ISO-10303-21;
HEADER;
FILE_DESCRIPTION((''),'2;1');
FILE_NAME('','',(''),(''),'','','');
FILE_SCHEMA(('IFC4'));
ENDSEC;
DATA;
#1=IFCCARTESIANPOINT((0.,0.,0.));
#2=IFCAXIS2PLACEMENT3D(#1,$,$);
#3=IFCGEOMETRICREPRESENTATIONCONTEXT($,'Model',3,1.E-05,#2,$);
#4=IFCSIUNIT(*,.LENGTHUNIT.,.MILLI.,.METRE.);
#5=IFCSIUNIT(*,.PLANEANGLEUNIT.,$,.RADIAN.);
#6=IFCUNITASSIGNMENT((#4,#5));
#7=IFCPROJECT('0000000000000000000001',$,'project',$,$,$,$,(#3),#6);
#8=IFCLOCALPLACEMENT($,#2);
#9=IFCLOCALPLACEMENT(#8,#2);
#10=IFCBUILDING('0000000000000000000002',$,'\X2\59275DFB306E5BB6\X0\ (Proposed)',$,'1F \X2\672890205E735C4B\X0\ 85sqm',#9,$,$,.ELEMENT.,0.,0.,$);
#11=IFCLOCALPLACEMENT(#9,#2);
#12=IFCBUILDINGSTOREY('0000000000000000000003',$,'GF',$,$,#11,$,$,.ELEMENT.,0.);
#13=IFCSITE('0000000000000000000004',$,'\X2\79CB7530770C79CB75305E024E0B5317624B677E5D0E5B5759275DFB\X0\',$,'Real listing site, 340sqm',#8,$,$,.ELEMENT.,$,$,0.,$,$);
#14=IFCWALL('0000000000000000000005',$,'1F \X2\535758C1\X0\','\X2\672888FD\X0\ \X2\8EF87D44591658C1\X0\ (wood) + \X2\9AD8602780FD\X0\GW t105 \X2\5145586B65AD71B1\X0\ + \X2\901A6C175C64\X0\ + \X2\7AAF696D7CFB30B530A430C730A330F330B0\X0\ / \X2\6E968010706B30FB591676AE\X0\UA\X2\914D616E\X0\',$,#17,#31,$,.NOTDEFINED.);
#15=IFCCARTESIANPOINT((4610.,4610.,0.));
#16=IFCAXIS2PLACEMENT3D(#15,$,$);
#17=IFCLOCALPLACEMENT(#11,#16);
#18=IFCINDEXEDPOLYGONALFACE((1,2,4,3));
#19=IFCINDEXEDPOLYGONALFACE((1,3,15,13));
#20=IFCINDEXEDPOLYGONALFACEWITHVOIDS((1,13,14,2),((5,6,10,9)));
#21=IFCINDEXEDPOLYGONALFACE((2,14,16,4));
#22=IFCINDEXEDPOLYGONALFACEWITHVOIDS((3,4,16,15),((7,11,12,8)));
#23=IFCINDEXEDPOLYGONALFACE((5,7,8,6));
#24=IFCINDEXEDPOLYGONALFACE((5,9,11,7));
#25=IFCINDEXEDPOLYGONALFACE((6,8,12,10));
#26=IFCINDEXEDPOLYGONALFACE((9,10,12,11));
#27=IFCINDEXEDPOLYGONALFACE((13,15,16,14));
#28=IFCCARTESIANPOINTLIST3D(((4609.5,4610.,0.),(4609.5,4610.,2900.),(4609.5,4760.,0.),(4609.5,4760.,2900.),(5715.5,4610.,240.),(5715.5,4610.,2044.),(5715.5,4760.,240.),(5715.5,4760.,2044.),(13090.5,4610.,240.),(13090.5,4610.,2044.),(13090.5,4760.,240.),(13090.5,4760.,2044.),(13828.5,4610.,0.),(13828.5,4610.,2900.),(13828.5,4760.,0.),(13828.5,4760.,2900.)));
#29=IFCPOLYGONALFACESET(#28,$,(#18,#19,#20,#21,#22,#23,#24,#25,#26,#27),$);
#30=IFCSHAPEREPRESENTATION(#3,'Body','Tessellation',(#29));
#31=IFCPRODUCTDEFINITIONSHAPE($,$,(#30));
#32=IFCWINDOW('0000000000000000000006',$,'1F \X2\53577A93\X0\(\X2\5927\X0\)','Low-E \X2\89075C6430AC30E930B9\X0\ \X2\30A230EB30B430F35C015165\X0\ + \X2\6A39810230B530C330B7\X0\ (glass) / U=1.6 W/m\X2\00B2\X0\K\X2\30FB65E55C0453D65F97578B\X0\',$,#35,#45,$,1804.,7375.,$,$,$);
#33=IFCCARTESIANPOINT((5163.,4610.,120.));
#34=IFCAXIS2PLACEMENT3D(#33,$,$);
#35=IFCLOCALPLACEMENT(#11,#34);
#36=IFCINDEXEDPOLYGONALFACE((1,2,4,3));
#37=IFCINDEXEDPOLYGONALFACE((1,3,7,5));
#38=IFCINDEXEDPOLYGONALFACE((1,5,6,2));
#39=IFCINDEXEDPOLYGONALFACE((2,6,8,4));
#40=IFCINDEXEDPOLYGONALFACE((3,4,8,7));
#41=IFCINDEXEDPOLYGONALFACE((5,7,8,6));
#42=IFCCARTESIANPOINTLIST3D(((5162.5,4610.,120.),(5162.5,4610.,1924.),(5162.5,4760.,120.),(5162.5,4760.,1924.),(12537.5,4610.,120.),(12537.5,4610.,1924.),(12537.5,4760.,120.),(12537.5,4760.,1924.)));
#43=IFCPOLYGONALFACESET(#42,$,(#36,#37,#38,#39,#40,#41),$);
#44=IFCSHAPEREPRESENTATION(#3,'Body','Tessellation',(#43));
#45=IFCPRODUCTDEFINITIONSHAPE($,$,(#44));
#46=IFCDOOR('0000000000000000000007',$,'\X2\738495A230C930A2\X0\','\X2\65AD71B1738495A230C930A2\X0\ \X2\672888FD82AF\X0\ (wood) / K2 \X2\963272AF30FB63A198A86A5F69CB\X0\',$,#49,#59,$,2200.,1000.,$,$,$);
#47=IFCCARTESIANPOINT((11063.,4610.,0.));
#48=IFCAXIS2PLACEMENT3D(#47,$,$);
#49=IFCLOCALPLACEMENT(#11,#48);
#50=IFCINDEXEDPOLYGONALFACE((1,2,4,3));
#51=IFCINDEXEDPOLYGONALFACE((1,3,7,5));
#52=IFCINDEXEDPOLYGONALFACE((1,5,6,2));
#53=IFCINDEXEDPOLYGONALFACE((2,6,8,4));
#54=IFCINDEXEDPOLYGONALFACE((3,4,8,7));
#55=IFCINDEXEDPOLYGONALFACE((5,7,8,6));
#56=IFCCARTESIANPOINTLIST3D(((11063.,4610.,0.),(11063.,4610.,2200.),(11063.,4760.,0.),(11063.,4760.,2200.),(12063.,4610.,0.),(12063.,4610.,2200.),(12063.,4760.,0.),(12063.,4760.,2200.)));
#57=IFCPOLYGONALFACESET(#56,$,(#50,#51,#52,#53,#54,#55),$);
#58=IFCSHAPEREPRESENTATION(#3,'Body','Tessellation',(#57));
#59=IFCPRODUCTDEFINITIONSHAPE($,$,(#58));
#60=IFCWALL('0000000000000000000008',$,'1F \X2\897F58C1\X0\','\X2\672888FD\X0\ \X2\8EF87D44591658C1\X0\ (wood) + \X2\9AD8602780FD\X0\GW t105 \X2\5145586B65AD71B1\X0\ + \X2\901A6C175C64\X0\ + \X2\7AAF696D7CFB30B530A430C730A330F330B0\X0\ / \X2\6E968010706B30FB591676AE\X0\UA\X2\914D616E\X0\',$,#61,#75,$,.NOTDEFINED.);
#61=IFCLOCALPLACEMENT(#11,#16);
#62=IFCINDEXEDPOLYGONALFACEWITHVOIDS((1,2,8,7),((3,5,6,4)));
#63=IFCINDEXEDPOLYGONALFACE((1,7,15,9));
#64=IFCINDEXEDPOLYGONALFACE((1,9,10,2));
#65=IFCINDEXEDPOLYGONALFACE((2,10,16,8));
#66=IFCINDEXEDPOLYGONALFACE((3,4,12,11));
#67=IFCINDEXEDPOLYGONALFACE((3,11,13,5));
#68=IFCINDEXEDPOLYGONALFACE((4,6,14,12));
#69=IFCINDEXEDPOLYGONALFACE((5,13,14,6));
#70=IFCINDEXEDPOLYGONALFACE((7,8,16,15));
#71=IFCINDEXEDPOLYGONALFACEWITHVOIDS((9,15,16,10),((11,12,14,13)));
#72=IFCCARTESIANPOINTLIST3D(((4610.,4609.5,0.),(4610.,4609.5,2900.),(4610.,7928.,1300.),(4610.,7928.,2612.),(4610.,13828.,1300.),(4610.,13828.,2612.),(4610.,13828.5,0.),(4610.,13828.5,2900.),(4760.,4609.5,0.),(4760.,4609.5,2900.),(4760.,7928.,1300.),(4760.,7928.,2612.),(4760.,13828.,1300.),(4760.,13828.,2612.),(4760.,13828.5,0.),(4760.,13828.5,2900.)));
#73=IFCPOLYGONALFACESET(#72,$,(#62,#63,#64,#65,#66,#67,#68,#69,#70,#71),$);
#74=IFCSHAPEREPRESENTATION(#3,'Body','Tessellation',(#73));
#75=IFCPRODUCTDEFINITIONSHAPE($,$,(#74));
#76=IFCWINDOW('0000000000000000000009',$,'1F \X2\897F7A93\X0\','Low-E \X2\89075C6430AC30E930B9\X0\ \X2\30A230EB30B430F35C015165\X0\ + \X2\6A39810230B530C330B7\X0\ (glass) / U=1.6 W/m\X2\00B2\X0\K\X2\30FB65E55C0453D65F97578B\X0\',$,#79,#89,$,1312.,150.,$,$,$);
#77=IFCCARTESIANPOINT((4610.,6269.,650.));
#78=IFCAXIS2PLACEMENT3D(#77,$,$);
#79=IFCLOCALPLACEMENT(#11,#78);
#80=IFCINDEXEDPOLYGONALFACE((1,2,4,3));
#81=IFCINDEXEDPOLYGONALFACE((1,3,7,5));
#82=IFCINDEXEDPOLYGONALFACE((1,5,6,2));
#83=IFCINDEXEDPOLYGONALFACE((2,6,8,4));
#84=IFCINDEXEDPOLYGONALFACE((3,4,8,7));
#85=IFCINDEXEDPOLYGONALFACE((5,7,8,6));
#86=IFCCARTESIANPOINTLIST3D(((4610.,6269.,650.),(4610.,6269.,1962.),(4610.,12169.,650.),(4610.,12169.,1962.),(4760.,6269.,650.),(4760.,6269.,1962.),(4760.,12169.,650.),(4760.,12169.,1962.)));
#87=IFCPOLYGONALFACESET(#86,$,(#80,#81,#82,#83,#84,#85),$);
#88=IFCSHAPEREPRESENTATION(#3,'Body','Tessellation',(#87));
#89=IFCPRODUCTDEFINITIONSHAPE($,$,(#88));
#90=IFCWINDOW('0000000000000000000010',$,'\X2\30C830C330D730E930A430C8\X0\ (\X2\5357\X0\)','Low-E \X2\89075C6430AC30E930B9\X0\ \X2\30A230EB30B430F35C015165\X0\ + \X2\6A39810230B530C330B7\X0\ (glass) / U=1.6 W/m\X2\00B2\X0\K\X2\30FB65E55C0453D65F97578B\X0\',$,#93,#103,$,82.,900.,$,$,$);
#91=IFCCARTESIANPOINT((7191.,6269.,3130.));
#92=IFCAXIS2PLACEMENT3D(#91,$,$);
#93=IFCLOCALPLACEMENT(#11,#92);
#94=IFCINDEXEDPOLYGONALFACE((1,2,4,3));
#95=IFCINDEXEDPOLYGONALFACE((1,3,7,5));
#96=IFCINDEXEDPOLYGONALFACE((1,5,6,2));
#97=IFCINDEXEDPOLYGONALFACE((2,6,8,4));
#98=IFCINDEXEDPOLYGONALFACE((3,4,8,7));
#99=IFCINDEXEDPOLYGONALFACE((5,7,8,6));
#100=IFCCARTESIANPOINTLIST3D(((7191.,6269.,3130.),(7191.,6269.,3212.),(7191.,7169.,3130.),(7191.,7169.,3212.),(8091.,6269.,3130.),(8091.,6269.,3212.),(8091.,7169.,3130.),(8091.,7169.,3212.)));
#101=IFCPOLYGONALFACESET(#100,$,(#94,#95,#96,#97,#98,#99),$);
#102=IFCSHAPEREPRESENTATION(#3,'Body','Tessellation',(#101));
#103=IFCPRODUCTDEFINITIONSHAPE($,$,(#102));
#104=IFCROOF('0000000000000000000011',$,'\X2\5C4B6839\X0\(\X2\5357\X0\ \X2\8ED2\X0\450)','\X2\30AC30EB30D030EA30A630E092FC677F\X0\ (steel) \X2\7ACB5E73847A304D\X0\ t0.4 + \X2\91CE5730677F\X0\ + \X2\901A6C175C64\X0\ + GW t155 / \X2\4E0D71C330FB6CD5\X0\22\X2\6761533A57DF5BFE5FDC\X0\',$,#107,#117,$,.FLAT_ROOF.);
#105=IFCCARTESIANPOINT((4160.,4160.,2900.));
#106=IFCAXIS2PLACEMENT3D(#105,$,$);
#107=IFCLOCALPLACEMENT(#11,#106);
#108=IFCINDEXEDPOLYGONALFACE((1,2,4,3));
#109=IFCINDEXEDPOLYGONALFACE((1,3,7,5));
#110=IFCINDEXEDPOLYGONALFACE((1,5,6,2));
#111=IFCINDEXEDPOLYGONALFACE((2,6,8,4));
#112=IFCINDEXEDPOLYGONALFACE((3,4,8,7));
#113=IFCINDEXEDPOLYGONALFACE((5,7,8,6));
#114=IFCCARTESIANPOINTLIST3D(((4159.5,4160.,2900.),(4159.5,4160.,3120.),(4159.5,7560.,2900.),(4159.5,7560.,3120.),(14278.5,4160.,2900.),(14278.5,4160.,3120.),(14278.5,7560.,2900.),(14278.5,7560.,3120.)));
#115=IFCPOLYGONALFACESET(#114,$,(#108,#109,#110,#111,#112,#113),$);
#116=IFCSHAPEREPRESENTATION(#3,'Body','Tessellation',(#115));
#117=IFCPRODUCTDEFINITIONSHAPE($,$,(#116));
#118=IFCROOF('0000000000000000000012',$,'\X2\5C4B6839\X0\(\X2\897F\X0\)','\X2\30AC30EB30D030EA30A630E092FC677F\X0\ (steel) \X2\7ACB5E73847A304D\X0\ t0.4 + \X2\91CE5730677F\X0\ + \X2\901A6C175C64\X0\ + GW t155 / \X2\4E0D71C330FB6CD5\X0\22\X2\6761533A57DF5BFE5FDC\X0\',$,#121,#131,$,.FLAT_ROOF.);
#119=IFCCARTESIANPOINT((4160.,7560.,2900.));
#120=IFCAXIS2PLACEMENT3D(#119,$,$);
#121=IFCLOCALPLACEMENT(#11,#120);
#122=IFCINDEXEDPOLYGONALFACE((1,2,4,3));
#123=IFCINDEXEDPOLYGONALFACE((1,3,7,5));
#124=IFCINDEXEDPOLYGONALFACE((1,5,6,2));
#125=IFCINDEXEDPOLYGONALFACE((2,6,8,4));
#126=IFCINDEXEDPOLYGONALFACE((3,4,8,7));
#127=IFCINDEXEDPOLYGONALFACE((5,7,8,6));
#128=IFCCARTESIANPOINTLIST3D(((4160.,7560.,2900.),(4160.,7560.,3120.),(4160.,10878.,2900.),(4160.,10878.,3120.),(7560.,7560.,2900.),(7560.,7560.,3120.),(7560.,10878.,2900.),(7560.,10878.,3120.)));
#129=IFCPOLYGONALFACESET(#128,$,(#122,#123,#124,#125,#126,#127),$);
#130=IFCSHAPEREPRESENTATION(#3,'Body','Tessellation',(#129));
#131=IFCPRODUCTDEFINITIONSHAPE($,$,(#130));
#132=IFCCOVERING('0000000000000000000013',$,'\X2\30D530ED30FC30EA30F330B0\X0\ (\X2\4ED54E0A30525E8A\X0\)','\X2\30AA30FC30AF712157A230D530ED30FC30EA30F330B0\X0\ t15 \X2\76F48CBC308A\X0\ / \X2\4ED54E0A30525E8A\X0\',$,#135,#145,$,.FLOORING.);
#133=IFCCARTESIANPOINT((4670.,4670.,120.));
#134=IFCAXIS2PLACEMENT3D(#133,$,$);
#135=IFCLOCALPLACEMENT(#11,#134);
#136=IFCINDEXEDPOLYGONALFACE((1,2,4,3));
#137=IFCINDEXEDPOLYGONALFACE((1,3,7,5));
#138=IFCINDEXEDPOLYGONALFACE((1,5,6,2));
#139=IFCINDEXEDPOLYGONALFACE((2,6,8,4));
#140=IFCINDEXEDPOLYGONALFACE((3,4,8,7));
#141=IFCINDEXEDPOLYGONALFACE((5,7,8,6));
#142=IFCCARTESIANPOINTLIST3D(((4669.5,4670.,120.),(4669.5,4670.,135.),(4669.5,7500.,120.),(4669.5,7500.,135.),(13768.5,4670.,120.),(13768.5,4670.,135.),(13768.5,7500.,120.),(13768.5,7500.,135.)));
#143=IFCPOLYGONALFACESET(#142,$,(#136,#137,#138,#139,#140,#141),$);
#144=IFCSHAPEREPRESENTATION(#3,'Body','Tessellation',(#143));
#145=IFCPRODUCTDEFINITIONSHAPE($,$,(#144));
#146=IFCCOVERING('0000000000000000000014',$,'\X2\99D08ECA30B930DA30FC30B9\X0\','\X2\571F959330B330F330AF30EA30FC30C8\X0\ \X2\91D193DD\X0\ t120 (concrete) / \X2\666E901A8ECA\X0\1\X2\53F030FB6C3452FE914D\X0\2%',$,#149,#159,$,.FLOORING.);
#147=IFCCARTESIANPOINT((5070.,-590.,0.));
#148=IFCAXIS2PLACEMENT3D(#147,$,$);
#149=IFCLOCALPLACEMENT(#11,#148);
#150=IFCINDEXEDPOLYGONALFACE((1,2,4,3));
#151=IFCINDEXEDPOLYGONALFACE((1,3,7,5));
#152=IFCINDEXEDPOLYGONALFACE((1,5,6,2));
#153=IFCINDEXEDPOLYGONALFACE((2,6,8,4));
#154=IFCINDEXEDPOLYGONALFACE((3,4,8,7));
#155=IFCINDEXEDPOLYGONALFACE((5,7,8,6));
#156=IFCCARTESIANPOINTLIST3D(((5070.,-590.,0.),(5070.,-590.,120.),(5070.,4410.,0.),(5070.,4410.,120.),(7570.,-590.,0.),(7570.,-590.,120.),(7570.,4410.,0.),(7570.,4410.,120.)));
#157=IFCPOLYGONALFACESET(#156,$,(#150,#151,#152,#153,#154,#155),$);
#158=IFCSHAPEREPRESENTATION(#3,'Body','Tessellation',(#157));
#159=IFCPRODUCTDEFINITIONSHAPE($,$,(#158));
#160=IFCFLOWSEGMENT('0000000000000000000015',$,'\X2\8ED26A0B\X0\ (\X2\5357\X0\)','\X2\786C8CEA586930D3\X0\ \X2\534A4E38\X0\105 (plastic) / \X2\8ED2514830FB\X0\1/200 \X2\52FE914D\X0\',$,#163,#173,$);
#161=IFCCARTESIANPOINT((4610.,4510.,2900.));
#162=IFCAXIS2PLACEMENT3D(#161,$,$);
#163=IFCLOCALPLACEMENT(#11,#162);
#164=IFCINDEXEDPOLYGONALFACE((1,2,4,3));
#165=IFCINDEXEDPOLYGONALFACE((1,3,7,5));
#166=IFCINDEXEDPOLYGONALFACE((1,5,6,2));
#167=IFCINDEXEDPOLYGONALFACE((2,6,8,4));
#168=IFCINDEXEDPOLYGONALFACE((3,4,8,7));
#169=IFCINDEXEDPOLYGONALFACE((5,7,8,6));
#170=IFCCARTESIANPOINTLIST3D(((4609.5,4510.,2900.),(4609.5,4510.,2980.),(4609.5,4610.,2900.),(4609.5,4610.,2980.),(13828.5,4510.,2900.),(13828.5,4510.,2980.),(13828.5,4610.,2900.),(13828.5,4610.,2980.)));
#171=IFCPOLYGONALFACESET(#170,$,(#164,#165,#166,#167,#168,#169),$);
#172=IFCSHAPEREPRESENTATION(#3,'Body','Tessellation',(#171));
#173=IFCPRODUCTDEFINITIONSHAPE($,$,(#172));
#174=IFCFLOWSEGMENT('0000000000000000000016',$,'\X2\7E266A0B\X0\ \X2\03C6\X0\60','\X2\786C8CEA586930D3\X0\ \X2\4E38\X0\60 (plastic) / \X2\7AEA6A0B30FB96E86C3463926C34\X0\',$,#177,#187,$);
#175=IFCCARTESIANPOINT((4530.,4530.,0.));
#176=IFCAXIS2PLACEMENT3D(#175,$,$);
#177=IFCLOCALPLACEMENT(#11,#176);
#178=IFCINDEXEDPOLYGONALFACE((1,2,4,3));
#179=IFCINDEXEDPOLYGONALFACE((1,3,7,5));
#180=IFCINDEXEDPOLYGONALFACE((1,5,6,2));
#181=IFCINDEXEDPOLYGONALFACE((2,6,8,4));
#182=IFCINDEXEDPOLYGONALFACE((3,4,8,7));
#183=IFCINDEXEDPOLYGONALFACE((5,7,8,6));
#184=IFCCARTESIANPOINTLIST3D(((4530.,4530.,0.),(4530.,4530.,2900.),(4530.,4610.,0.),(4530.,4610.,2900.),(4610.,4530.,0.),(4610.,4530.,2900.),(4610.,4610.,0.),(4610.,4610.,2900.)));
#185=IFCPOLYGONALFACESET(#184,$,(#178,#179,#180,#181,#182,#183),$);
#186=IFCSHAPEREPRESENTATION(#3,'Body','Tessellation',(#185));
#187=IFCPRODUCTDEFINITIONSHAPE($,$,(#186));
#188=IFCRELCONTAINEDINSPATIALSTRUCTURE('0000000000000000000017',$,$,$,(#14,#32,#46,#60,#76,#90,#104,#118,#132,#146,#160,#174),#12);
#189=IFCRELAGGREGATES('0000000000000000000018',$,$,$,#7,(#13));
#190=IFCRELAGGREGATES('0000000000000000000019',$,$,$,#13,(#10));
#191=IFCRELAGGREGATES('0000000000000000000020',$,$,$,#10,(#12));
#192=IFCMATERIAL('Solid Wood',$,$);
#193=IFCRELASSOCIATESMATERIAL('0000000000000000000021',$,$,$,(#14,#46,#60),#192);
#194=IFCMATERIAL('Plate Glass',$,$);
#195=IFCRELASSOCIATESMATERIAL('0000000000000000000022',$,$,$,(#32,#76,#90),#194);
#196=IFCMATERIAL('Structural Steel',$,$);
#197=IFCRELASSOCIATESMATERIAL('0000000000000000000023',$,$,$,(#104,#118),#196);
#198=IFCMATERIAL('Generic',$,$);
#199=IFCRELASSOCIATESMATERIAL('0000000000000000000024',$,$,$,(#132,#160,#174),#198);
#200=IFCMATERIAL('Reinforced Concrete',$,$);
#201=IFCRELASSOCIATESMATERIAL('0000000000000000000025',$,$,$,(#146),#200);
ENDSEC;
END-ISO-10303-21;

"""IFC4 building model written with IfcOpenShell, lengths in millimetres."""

from ifc_helpers import new_model, si_unit, frame, frame_2d, origin, place, context, project, spatial, rectangle, extrude, material, element, fill, save


model = new_model("IFC4")

# Units and contexts
model_context = context("Model", 3, precision=1e-05, world=origin())
ifc_project = project(units=[si_unit("LENGTHUNIT", "METRE", prefix="MILLI"), si_unit("PLANEANGLEUNIT", "RADIAN")], contexts=[model_context])

# Site, building, storey
site_placement = place(None, origin())
site = spatial("IfcSite", under=ifc_project, at=site_placement, Name="秋田県秋田市下北手松崎字大巻", ObjectType="Real listing site, 340sqm", CompositionType="ELEMENT", RefElevation=0.0)
building_placement = place(site_placement, origin())
building = spatial("IfcBuilding", under=site, at=building_placement, Name="大巻の家 (Proposed)", ObjectType="1F 木造平屋 85sqm", CompositionType="ELEMENT", ElevationOfRefHeight=0.0, ElevationOfTerrain=0.0)
storey_placement = place(building_placement, origin())
storey = spatial("IfcBuildingStorey", under=building, at=storey_placement, Name="GF", CompositionType="ELEMENT", Elevation=0.0)

# Shared definitions
ifc_material_1 = material(Name="Solid Wood")

# Shared definitions
ifc_material_2 = material(Name="Reinforced Concrete")

# Wall, openings, window, door
wall_1_placement = place(storey_placement, frame((4610.0, 4610.0, 0.0)))
wall_1 = element("IfcWall", 1, at=wall_1_placement, inside=storey, material=ifc_material_1, Name="1F 南壁", Description="木製 軸組外壁 (wood) + 高性能GW t105 充填断熱 + 通気層 + 窯業系サイディング / 準耐火・外皮UA配慮", PredefinedType="NOTDEFINED", context=model_context, shape_type="SweptSolid", body=[
    extrude(rectangle(XDim=9219.0, YDim=150.0, at=frame_2d((4609.0, 75.0))), frame((4610.0, 4610.0, 0.0)), (0.0, 0.0, 1.0), 2900.0),
])
opening_1_placement = place(storey_placement, frame((5163.0, 4610.0, 120.0)))
opening_1 = element("IfcOpeningElement", 2, at=opening_1_placement, cuts=wall_1, PredefinedType="NOTDEFINED", context=model_context, shape_type="SweptSolid", body=[
    extrude(rectangle(XDim=7375.0, YDim=150.0, at=frame_2d((3687.0, 75.0))), frame((5163.0, 4610.0, 120.0)), (0.0, 0.0, 1.0), 1804.0),
])
opening_2_placement = place(storey_placement, frame((11063.0, 4610.0, 0.0)))
opening_2 = element("IfcOpeningElement", 3, at=opening_2_placement, cuts=wall_1, PredefinedType="NOTDEFINED", context=model_context, shape_type="SweptSolid", body=[
    extrude(rectangle(XDim=1000.0, YDim=150.0, at=frame_2d((500.0, 75.0))), frame((11063.0, 4610.0, 0.0)), (0.0, 0.0, 1.0), 2200.0),
])
ifc_material_3 = material(Name="Plate Glass")
window_1_placement = place(storey_placement, frame((5163.0, 4610.0, 120.0)))
window_1 = element("IfcWindow", 4, at=window_1_placement, inside=storey, material=ifc_material_3, Name="1F 南窓(大)", Description="Low-E 複層ガラス アルゴン封入 + 樹脂サッシ (glass) / U=1.6 W/m²K・日射取得型", OverallHeight=1804.0, OverallWidth=7375.0, context=model_context, shape_type="SweptSolid", body=[
    extrude(rectangle(XDim=7375.0, YDim=150.0, at=frame_2d((3687.0, 75.0))), frame((5163.0, 4610.0, 120.0)), (0.0, 0.0, 1.0), 1804.0),
])
fill(opening_1, window_1)
door_placement = place(storey_placement, frame((11063.0, 4610.0, 0.0)))
door = element("IfcDoor", 5, at=door_placement, inside=storey, material=ifc_material_1, Name="玄関ドア", Description="断熱玄関ドア 木製芯 (wood) / K2 防犯・採風機構", OverallHeight=2200.0, OverallWidth=1000.0, context=model_context, shape_type="SweptSolid", body=[
    extrude(rectangle(XDim=1000.0, YDim=150.0, at=frame_2d((500.0, 75.0))), frame((11063.0, 4610.0, 0.0)), (0.0, 0.0, 1.0), 2200.0),
])
fill(opening_2, door)

# Wall, opening, window
wall_2_placement = place(storey_placement, frame((4610.0, 4610.0, 0.0)))
wall_2 = element("IfcWall", 6, at=wall_2_placement, inside=storey, material=ifc_material_1, Name="1F 西壁", Description="木製 軸組外壁 (wood) + 高性能GW t105 充填断熱 + 通気層 + 窯業系サイディング / 準耐火・外皮UA配慮", PredefinedType="NOTDEFINED", context=model_context, shape_type="SweptSolid", body=[
    extrude(rectangle(XDim=150.0, YDim=9219.0, at=frame_2d((75.0, 4609.0))), frame((4610.0, 4610.0, 0.0)), (0.0, 0.0, 1.0), 2900.0),
])
opening_3_placement = place(storey_placement, frame((4610.0, 6269.0, 650.0)))
opening_3 = element("IfcOpeningElement", 7, at=opening_3_placement, cuts=wall_2, PredefinedType="NOTDEFINED", context=model_context, shape_type="SweptSolid", body=[
    extrude(rectangle(XDim=150.0, YDim=5900.0, at=frame_2d((75.0, 2950.0))), frame((4610.0, 6269.0, 650.0)), (0.0, 0.0, 1.0), 1312.0),
])
window_2_placement = place(storey_placement, frame((4610.0, 6269.0, 650.0)))
window_2 = element("IfcWindow", 8, at=window_2_placement, inside=storey, material=ifc_material_3, Name="1F 西窓", Description="Low-E 複層ガラス アルゴン封入 + 樹脂サッシ (glass) / U=1.6 W/m²K・日射取得型", OverallHeight=1312.0, OverallWidth=150.0, context=model_context, shape_type="SweptSolid", body=[
    extrude(rectangle(XDim=150.0, YDim=5900.0, at=frame_2d((75.0, 2950.0))), frame((4610.0, 6269.0, 650.0)), (0.0, 0.0, 1.0), 1312.0),
])
fill(opening_3, window_2)

# Window
window_3_placement = place(storey_placement, frame((7191.0, 6269.0, 3130.0)))
element("IfcWindow", 9, at=window_3_placement, inside=storey, material=ifc_material_3, Name="トップライト (南)", Description="Low-E 複層ガラス アルゴン封入 + 樹脂サッシ (glass) / U=1.6 W/m²K・日射取得型", OverallHeight=82.0, OverallWidth=900.0, context=model_context, shape_type="SweptSolid", body=[
    extrude(rectangle(XDim=900.0, YDim=900.0, at=frame_2d((450.0, 450.0))), frame((7191.0, 6269.0, 3130.0)), (0.0, 0.0, 1.0), 82.0),
])

# Roofs
ifc_material_4 = material(Name="Structural Steel")
roof_1_placement = place(storey_placement, frame((4160.0, 4160.0, 2900.0)))
element("IfcRoof", 10, at=roof_1_placement, inside=storey, material=ifc_material_4, Name="屋根(南 軒450)", Description="ガルバリウム鋼板 (steel) 立平葺き t0.4 + 野地板 + 通気層 + GW t155 / 不燃・法22条区域対応", PredefinedType="FLAT_ROOF", context=model_context, shape_type="SweptSolid", body=[
    extrude(rectangle(XDim=10119.0, YDim=3400.0, at=frame_2d((5059.0, 1700.0))), frame((4160.0, 4160.0, 2900.0)), (0.0, 0.0, 1.0), 220.0),
])
roof_2_placement = place(storey_placement, frame((4160.0, 7560.0, 2900.0)))
element("IfcRoof", 11, at=roof_2_placement, inside=storey, material=ifc_material_4, Name="屋根(西)", Description="ガルバリウム鋼板 (steel) 立平葺き t0.4 + 野地板 + 通気層 + GW t155 / 不燃・法22条区域対応", PredefinedType="FLAT_ROOF", context=model_context, shape_type="SweptSolid", body=[
    extrude(rectangle(XDim=3400.0, YDim=3318.0, at=frame_2d((1700.0, 1659.0))), frame((4160.0, 7560.0, 2900.0)), (0.0, 0.0, 1.0), 220.0),
])

# Coverings
ifc_material_5 = material(Name="Generic")
covering_1_placement = place(storey_placement, frame((4670.0, 4670.0, 120.0)))
element("IfcCovering", 12, at=covering_1_placement, inside=storey, material=ifc_material_5, Name="フローリング (仕上げ床)", Description="オーク無垢フローリング t15 直貼り / 仕上げ床", PredefinedType="FLOORING", context=model_context, shape_type="SweptSolid", body=[
    extrude(rectangle(XDim=9099.0, YDim=2830.0, at=frame_2d((4549.0, 1415.0))), frame((4670.0, 4670.0, 120.0)), (0.0, 0.0, 1.0), 15.0),
])
covering_2_placement = place(storey_placement, frame((5070.0, -590.0, 0.0)))
element("IfcCovering", 13, at=covering_2_placement, inside=storey, material=ifc_material_2, Name="駐車スペース", Description="土間コンクリート 金鏝 t120 (concrete) / 普通車1台・水勾配2%", PredefinedType="FLOORING", context=model_context, shape_type="SweptSolid", body=[
    extrude(rectangle(XDim=2500.0, YDim=5000.0, at=frame_2d((1250.0, 2500.0))), frame((5070.0, -590.0, 0.0)), (0.0, 0.0, 1.0), 120.0),
])

# Flow segments
flow_segment_1_placement = place(storey_placement, frame((4610.0, 4510.0, 2900.0)))
element("IfcFlowSegment", 14, at=flow_segment_1_placement, inside=storey, material=ifc_material_5, Name="軒樋 (南)", Description="硬質塩ビ 半丸105 (plastic) / 軒先・1/200 勾配", context=model_context, shape_type="SweptSolid", body=[
    extrude(rectangle(XDim=9219.0, YDim=100.0, at=frame_2d((4609.0, 50.0))), frame((4610.0, 4510.0, 2900.0)), (0.0, 0.0, 1.0), 80.0),
])
flow_segment_2_placement = place(storey_placement, frame((4530.0, 4530.0, 0.0)))
element("IfcFlowSegment", 15, at=flow_segment_2_placement, inside=storey, material=ifc_material_5, Name="縦樋 φ60", Description="硬質塩ビ 丸60 (plastic) / 竪樋・雨水排水", context=model_context, shape_type="SweptSolid", body=[
    extrude(rectangle(XDim=80.0, YDim=80.0, at=frame_2d((40.0, 40.0))), frame((4530.0, 4530.0, 0.0)), (0.0, 0.0, 1.0), 2900.0),
])

save(model, "model.ifc")
